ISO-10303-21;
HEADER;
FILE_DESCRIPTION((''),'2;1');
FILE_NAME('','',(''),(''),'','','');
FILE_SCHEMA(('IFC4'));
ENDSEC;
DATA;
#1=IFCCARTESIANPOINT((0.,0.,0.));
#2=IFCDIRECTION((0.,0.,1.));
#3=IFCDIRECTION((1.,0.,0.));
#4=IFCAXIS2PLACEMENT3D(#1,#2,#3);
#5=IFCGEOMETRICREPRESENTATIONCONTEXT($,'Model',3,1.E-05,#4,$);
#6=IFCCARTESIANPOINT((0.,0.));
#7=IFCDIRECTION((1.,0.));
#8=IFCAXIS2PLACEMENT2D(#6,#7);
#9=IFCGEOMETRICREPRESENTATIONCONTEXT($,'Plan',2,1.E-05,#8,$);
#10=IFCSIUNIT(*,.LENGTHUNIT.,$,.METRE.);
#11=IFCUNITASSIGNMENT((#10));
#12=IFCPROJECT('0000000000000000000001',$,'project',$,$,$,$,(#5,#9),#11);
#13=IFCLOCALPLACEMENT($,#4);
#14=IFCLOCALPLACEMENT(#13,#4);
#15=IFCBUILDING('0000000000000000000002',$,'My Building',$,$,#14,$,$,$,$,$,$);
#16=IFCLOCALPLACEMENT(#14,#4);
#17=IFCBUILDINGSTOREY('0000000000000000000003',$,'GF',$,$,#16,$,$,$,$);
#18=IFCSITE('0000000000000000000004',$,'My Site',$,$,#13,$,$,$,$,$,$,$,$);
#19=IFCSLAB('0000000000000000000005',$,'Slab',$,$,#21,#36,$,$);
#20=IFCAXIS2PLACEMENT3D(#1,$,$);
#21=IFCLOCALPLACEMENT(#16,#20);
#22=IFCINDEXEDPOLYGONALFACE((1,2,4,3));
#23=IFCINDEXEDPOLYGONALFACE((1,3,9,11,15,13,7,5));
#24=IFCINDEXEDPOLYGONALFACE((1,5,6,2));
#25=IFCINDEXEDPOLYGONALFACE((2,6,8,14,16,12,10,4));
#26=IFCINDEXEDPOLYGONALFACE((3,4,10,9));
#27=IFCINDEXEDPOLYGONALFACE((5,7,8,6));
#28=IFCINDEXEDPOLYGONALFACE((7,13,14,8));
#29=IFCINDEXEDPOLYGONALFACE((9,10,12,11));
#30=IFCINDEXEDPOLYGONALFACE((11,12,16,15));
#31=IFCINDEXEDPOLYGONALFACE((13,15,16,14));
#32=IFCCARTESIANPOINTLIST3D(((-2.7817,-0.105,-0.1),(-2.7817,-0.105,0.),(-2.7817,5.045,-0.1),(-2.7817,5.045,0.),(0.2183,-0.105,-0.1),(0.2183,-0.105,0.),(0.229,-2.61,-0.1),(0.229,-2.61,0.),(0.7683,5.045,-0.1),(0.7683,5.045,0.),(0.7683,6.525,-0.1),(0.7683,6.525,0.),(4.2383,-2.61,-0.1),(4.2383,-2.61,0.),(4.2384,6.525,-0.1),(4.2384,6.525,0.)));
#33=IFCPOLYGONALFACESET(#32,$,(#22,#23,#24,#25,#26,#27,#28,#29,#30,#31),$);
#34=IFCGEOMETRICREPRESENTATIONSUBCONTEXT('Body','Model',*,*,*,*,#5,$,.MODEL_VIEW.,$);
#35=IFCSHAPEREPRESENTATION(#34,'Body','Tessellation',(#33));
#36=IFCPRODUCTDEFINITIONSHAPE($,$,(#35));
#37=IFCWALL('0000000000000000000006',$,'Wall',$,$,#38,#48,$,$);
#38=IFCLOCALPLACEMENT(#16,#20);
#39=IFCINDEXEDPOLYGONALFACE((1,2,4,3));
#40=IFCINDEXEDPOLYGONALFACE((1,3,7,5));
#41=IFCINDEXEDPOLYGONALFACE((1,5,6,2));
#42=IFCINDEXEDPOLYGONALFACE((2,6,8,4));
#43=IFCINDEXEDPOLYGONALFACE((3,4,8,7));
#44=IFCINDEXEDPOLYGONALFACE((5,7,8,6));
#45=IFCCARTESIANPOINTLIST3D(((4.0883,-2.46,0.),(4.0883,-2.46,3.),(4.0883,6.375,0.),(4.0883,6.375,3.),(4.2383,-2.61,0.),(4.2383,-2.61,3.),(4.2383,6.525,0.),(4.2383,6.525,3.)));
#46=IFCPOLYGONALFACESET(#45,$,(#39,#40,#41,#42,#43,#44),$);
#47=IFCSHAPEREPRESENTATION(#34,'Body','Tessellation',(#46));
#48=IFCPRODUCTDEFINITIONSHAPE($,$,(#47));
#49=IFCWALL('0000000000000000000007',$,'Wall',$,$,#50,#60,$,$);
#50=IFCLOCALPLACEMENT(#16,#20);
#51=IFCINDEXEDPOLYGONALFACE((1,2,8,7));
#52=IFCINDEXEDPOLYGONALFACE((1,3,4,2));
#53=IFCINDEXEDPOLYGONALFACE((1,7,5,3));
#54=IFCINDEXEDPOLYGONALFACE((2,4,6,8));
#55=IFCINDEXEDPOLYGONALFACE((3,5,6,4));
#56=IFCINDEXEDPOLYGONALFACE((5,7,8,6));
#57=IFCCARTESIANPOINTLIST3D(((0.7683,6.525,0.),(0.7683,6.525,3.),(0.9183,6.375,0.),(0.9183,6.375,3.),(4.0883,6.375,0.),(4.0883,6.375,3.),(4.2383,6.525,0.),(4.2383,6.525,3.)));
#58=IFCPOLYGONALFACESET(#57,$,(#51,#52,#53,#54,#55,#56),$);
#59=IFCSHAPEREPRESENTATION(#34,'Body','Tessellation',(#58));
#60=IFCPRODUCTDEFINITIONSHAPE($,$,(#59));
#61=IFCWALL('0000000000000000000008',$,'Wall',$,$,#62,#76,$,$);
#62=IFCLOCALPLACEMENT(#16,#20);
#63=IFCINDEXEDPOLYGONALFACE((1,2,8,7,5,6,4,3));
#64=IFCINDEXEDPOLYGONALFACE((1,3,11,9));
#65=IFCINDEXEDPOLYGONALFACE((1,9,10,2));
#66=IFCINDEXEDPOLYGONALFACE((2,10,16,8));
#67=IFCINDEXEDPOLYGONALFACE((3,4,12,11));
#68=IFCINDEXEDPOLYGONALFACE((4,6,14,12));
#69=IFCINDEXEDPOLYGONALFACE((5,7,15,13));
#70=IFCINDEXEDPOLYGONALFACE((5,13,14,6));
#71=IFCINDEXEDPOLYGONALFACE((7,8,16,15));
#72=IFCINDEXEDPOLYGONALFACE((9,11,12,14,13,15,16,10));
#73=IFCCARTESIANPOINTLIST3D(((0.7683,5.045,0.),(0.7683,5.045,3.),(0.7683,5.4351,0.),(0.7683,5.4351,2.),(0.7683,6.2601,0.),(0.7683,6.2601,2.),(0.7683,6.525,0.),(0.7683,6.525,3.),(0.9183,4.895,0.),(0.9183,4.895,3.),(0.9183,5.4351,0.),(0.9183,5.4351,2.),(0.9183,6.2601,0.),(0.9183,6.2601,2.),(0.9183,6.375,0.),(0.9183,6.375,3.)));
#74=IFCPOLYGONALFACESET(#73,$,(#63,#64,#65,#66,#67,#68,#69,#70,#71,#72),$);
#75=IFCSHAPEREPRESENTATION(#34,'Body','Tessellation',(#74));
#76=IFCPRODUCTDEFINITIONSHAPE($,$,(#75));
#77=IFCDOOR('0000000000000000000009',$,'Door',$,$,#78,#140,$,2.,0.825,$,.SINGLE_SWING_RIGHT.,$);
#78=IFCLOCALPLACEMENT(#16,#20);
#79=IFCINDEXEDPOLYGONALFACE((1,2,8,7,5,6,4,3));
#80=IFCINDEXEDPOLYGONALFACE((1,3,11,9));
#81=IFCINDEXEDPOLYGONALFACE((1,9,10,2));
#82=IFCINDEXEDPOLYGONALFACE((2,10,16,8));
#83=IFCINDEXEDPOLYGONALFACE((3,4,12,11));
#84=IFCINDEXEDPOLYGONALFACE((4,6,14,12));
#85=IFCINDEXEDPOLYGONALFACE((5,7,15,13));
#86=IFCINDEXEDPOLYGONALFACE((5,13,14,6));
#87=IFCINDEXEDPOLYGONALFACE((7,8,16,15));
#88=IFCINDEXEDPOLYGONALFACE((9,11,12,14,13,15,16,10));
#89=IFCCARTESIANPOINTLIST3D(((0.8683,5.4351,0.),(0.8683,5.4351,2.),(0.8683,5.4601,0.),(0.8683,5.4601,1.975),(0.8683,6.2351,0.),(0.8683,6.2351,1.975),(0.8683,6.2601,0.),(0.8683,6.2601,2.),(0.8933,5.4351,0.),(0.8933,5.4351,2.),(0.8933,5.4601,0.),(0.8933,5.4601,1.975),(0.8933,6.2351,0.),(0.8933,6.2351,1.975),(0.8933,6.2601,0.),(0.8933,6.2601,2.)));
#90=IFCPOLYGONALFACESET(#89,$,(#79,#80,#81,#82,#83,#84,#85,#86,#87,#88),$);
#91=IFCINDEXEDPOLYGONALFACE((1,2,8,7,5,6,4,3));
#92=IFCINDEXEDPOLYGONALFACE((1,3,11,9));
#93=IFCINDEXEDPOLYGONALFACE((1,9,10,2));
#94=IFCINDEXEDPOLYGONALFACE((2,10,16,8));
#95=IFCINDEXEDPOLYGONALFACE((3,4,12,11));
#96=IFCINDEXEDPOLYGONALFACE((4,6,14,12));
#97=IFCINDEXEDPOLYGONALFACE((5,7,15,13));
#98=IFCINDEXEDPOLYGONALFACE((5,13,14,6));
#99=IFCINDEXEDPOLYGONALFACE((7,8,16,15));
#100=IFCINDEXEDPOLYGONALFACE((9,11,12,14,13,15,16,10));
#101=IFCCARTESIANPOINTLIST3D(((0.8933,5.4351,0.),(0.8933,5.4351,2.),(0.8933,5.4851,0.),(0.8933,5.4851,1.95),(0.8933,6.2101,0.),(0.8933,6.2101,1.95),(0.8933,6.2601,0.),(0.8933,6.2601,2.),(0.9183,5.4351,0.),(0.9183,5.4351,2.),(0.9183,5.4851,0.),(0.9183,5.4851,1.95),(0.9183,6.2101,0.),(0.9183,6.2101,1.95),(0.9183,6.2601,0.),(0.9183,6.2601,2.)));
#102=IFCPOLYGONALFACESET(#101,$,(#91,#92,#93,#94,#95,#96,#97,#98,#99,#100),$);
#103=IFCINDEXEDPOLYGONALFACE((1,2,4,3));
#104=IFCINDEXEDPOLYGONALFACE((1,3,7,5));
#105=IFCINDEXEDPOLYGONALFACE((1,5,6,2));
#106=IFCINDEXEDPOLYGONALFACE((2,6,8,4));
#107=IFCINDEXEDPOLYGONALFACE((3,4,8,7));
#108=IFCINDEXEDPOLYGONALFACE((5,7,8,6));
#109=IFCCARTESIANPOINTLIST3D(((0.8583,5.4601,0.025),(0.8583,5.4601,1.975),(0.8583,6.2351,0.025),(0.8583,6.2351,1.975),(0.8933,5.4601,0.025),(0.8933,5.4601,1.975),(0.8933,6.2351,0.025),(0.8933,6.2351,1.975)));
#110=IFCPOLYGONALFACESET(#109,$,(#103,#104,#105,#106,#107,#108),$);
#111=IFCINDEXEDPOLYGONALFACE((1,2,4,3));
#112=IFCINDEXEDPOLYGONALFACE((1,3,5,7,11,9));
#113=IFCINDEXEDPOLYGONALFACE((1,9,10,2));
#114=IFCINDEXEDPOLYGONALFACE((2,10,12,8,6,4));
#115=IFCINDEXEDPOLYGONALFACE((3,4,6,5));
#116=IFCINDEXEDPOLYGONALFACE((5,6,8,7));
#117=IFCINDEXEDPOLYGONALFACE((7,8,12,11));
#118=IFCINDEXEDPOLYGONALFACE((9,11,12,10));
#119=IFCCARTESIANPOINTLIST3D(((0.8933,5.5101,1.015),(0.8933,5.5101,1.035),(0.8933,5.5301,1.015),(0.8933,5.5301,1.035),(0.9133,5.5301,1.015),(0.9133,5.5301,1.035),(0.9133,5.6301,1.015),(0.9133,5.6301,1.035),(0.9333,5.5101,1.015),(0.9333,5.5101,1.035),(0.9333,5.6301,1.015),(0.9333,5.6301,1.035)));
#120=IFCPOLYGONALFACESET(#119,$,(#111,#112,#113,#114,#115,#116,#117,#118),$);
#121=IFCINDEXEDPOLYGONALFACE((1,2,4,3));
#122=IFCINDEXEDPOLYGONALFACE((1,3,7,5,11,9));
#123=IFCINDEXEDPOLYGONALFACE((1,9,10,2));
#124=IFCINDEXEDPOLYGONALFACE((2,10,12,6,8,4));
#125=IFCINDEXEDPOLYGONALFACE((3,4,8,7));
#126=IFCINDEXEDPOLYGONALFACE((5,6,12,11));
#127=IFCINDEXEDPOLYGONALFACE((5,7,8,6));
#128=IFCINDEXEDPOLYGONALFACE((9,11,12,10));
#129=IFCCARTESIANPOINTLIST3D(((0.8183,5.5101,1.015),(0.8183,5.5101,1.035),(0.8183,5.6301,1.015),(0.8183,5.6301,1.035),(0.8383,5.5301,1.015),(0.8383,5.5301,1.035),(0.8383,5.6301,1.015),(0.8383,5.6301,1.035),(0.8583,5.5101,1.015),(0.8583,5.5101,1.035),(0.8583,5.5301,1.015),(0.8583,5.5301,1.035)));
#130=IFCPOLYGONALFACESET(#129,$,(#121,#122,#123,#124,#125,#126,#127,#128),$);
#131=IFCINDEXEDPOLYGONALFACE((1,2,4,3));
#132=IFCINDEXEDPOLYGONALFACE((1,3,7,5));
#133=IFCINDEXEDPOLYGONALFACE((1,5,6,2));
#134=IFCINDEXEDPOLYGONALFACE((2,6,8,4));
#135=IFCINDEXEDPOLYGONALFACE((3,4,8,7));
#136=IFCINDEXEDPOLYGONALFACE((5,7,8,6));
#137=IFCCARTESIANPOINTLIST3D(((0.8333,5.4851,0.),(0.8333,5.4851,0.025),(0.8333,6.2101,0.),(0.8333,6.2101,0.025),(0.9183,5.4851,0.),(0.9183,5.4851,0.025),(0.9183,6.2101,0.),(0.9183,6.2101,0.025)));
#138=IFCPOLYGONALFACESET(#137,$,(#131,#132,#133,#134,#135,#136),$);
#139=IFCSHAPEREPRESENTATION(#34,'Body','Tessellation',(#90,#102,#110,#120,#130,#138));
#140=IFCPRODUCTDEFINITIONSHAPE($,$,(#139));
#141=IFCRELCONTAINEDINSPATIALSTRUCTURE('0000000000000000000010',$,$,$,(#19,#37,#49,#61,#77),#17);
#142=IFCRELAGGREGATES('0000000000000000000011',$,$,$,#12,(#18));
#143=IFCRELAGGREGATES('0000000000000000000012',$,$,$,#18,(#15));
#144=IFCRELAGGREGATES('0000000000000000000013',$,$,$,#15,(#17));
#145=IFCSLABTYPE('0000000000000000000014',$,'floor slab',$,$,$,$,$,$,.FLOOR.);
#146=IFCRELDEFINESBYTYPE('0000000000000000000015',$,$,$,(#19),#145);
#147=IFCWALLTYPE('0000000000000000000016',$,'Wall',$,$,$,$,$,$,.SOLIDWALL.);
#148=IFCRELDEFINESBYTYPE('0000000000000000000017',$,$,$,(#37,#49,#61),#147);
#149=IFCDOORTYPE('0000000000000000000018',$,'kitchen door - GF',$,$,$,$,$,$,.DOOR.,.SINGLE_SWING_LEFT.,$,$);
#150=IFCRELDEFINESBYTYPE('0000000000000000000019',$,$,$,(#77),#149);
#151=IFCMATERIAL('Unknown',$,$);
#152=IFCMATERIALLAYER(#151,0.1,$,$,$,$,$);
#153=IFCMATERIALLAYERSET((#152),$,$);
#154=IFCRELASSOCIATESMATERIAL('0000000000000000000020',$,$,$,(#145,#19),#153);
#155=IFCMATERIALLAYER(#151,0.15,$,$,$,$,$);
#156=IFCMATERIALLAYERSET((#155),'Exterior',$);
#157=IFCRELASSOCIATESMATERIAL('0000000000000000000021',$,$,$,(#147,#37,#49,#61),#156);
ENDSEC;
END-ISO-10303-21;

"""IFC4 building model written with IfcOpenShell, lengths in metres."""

from ifc_helpers import new_model, entity, si_unit, frame, origin_with_axes, origin_2d_with_axis, place, context, subcontext, project, spatial, line, indexed_curve, outline, extrude, shape, source, transform, mapped, material, layer, layer_set, layer_usage, type_object, type_shapes, element, fill, save


model = new_model("IFC4")

# Units and contexts
model_context = context("Model", 3, precision=1e-05, world=origin_with_axes())
plan_context = context("Plan", 2, precision=1e-05, world=origin_2d_with_axis())
body_context_1 = subcontext(model_context, "Body", "Model", "MODEL_VIEW")
body_context_2 = subcontext(plan_context, "Body", "Plan", "PLAN_VIEW")
ifc_project = project(units=[si_unit("LENGTHUNIT", "METRE")], contexts=[model_context, plan_context])

# Site, building, storey
site_placement = place(None, origin_with_axes())
site = spatial("IfcSite", under=ifc_project, at=site_placement, Name="My Site")
building_placement = place(site_placement, origin_with_axes())
building = spatial("IfcBuilding", under=site, at=building_placement, Name="My Building")
storey_placement = place(building_placement, origin_with_axes())
storey = spatial("IfcBuildingStorey", under=building, at=storey_placement, Name="GF")

# Slab
ifc_material = material(Name="Unknown")
ifc_layer_1 = layer(ifc_material, 0.1)
ifc_layer_set_1 = layer_set([ifc_layer_1])
ifc_layer_usage_1 = layer_usage(ifc_layer_set_1, "AXIS3", "POSITIVE", -0.1)
slab_type = type_object("IfcSlabType", Name="floor slab", PredefinedType="FLOOR", material=ifc_layer_set_1)
slab_placement = place(storey_placement, frame((4.2383, -2.61, 0.0), z_axis=(0.0, 0.0, 1.0), x_axis=(1.0, 0.0, 0.0)))
element("IfcSlab", 1, at=slab_placement, inside=storey, type_object=slab_type, material=ifc_layer_usage_1, Name="Slab", context=body_context_1, shape_type="SweptSolid", body=[
    extrude(outline(indexed_curve([(0.0, 0.0), (0.0, 9.135), (-3.47, 9.135), (-3.47, 7.655), (-7.02, 7.655), (-7.02, 2.505), (-4.02, 2.505), (-4.0094, 0.0), (0.0, 0.0)])), frame((0.0, 0.0, -0.1), z_axis=(0.0, 0.0, 1.0), x_axis=(1.0, 0.0, 0.0)), (0.0, 0.0, 1.0), 0.1),
])

# Shared definitions
ifc_layer_2 = layer(ifc_material, 0.15)
ifc_layer_set_2 = layer_set([ifc_layer_2], Name="Exterior")
wall_type_1 = type_object("IfcWallType", Name="Wall", PredefinedType="SOLIDWALL", material=ifc_layer_set_2)

# Walls
ifc_layer_usage_2 = layer_usage(ifc_layer_set_2, "AXIS2", "POSITIVE", 0.0)
wall_1_placement = place(storey_placement, frame((4.2383, -2.61, 0.0), z_axis=(0.0, 0.0, 1.0), x_axis=(0.0, 1.0, 0.0)))
element("IfcWall", 2, at=wall_1_placement, inside=storey, type_object=wall_type_1, material=ifc_layer_usage_2, Name="Wall", context=body_context_1, shape_type="SweptSolid", body=[
    extrude(outline(indexed_curve([(0.0, 0.0), (0.15, 0.15), (8.985, 0.15), (9.135, 0.0)], segments=[line(1, 2, 3, 4, 1)])), origin_with_axes(), (0.0, 0.0, 1.0), 3.0),
])
ifc_layer_usage_3 = layer_usage(ifc_layer_set_2, "AXIS2", "POSITIVE", 0.0)
wall_2_placement = place(storey_placement, frame((4.2383, 6.525, 0.0), z_axis=(0.0, 0.0, 1.0), x_axis=(-1.0, 0.0, 0.0)))
element("IfcWall", 3, at=wall_2_placement, inside=storey, type_object=wall_type_1, material=ifc_layer_usage_3, Name="Wall", context=body_context_1, shape_type="SweptSolid", body=[
    extrude(outline(indexed_curve([(0.0, 0.0), (0.15, 0.15), (3.32, 0.15), (3.47, 0.0)], segments=[line(1, 2, 3, 4, 1)])), origin_with_axes(), (0.0, 0.0, 1.0), 3.0),
])

# Wall, opening, door
ifc_layer_usage_4 = layer_usage(ifc_layer_set_2, "AXIS2", "POSITIVE", 0.0)
wall_3_placement = place(storey_placement, frame((0.7683, 6.525, 0.0), z_axis=(0.0, 0.0, 1.0), x_axis=(0.0, -1.0, 0.0)))
wall_3 = element("IfcWall", 4, at=wall_3_placement, inside=storey, type_object=wall_type_1, material=ifc_layer_usage_4, Name="Wall", context=body_context_1, shape_type="SweptSolid", body=[
    extrude(outline(indexed_curve([(0.0, 0.0), (0.15, 0.15), (1.63, 0.15), (1.48, 0.0)], segments=[line(1, 2, 3, 4, 1)])), origin_with_axes(), (0.0, 0.0, 1.0), 3.0),
])
shared_shape_1 = source(origin_with_axes(), body_context_1, "Body", "SweptSolid", [
    extrude(outline(indexed_curve([(0.0, 0.0), (0.825, 0.0), (0.825, 2.0), (0.0, 2.0)], segments=[line(1, 2, 3, 4, 1)])), frame((0.0, -0.6, 0.0), z_axis=(0.0, -1.0, 0.0), x_axis=(1.0, 0.0, 0.0)), (0.0, 0.0, -1.0), 1.2),
])
opening_1_placement = place(wall_3_placement, frame((1.0898, 0.15, 0.0), z_axis=(0.0, 0.0, 1.0), x_axis=(-1.0, 0.0, 0.0)))
opening_1 = element("IfcOpeningElement", 5, at=opening_1_placement, cuts=wall_3, PredefinedType="OPENING", context=body_context_1, shape_type="MappedRepresentation", body=[
    mapped(shared_shape_1, transform((0.0, 0.0, 0.0), x_axis=(1.0, 0.0, 0.0), y_axis=(0.0, 1.0, 0.0), z_axis=(0.0, 0.0, 1.0), scale=1.0)),
])
door_type_1 = type_object("IfcDoorType", Name="kitchen door - GF", OperationType="SINGLE_SWING_LEFT", PredefinedType="DOOR")
shared_shape_2 = source(origin_with_axes(), body_context_1, "Body", "SweptSolid", [
    extrude(outline(indexed_curve([(0.0, 0.0), (0.0, 2.0), (0.825, 2.0), (0.825, 0.0), (0.8, 0.0), (0.8, 1.975), (0.025, 1.975), (0.025, 0.0)], segments=[line(1, 2, 3, 4, 5, 6, 7, 8, 1)])), frame((0.0, 0.025, 0.0), z_axis=(0.0, -1.0, 0.0), x_axis=(1.0, 0.0, 0.0)), (0.0, 0.0, -1.0), 0.025),
    extrude(outline(indexed_curve([(0.0, 0.0), (0.0, 2.0), (0.825, 2.0), (0.825, 0.0), (0.775, 0.0), (0.775, 1.95), (0.05, 1.95), (0.05, 0.0)], segments=[line(1, 2, 3, 4, 5, 6, 7, 8, 1)])), frame((0.0, 0.0, 0.0), z_axis=(0.0, -1.0, 0.0), x_axis=(1.0, 0.0, 0.0)), (0.0, 0.0, -1.0), 0.025),
    extrude(outline(indexed_curve([(0.0, 0.0), (0.775, 0.0), (0.775, 0.035), (0.0, 0.035)], segments=[line(1, 2, 3, 4, 1)])), frame((0.025, 0.025, 0.025), z_axis=(0.0, 0.0, 1.0), x_axis=(1.0, 0.0, 0.0)), (0.0, 0.0, 1.0), 1.95),
    extrude(outline(indexed_curve([(0.0, 0.0), (0.0, -0.04), (0.12, -0.04), (0.12, -0.02), (0.02, -0.02), (0.02, 0.0)], segments=[line(1, 2, 3, 4, 5, 6, 1)])), frame((0.075, 0.025, 1.015), z_axis=(0.0, 0.0, 1.0), x_axis=(1.0, 0.0, 0.0)), (0.0, 0.0, 1.0), 0.02),
    extrude(outline(indexed_curve([(0.0, 0.0), (0.0, 0.04), (0.12, 0.04), (0.12, 0.02), (0.02, 0.02), (0.02, 0.0)], segments=[line(1, 2, 3, 4, 5, 6, 1)])), frame((0.075, 0.06, 1.015), z_axis=(0.0, 0.0, 1.0), x_axis=(1.0, 0.0, 0.0)), (0.0, 0.0, 1.0), 0.02),
    extrude(outline(indexed_curve([(0.0, 0.0), (0.725, 0.0), (0.725, 0.085), (0.0, 0.085)], segments=[line(1, 2, 3, 4, 1)])), frame((0.05, 0.0, 0.0), z_axis=(0.0, 0.0, 1.0), x_axis=(1.0, 0.0, 0.0)), (0.0, 0.0, 1.0), 0.025),
])
shared_shape_3 = source(origin_with_axes(), body_context_2, "Body", "Curve2D", [
    entity("IfcIndexedPolyCurve", entity("IfcCartesianPointList2D", [[0.0, 0.0], [0.0, 0.05], [0.025, 0.05], [0.025, 0.025], [0.05, 0.025], [0.05, 0.0]]), [entity("IfcLineIndex", [1, 2, 3, 4, 5, 6, 1])]),
    entity("IfcIndexedPolyCurve", entity("IfcCartesianPointList2D", [[0.825, 0.0], [0.825, 0.05], [0.8, 0.05], [0.8, 0.025], [0.775, 0.025], [0.775, 0.0]]), [entity("IfcLineIndex", [1, 2, 3, 4, 5, 6, 1])]),
    entity("IfcTrimmedCurve", entity("IfcEllipse", entity("IfcAxis2Placement2D", entity("IfcCartesianPoint", [0.765, 0.05]), entity("IfcDirection", [1.0, 0.0])), 0.74, 0.775), [entity("IfcCartesianPoint", [0.765, 0.825])], [entity("IfcCartesianPoint", [0.025, 0.05])], True, "CARTESIAN"),
    entity("IfcIndexedPolyCurve", entity("IfcCartesianPointList2D", [[0.8, 0.05], [0.765, 0.05], [0.765, 0.825], [0.8, 0.825]]), [entity("IfcLineIndex", [1, 2, 3, 4, 1])]),
])
type_shapes(door_type_1, [shared_shape_2, shared_shape_3])
door_1_placement = place(opening_1_placement, frame((0.0, 0.0, 0.0), z_axis=(0.0, 0.0, 1.0), x_axis=(1.0, 0.0, 0.0)))
door_1 = element("IfcDoor", 6, at=door_1_placement, inside=storey, type_object=door_type_1, Name="Door", OperationType="SINGLE_SWING_RIGHT", OverallHeight=2.0, OverallWidth=0.825, shapes=[
    shape(body_context_1, "Body", "MappedRepresentation", [mapped(shared_shape_2, transform((0.0, 0.0, 0.0), x_axis=(1.0, 0.0, 0.0), y_axis=(0.0, 1.0, 0.0), z_axis=(0.0, 0.0, 1.0), scale=1.0))]),
    shape(body_context_2, "Body", "MappedRepresentation", [mapped(shared_shape_3, transform((0.0, 0.0, 0.0), x_axis=(1.0, 0.0, 0.0), y_axis=(0.0, 1.0, 0.0), z_axis=(0.0, 0.0, 1.0), scale=1.0))]),
])
fill(opening_1, door_1)

save(model, "model.ifc")
